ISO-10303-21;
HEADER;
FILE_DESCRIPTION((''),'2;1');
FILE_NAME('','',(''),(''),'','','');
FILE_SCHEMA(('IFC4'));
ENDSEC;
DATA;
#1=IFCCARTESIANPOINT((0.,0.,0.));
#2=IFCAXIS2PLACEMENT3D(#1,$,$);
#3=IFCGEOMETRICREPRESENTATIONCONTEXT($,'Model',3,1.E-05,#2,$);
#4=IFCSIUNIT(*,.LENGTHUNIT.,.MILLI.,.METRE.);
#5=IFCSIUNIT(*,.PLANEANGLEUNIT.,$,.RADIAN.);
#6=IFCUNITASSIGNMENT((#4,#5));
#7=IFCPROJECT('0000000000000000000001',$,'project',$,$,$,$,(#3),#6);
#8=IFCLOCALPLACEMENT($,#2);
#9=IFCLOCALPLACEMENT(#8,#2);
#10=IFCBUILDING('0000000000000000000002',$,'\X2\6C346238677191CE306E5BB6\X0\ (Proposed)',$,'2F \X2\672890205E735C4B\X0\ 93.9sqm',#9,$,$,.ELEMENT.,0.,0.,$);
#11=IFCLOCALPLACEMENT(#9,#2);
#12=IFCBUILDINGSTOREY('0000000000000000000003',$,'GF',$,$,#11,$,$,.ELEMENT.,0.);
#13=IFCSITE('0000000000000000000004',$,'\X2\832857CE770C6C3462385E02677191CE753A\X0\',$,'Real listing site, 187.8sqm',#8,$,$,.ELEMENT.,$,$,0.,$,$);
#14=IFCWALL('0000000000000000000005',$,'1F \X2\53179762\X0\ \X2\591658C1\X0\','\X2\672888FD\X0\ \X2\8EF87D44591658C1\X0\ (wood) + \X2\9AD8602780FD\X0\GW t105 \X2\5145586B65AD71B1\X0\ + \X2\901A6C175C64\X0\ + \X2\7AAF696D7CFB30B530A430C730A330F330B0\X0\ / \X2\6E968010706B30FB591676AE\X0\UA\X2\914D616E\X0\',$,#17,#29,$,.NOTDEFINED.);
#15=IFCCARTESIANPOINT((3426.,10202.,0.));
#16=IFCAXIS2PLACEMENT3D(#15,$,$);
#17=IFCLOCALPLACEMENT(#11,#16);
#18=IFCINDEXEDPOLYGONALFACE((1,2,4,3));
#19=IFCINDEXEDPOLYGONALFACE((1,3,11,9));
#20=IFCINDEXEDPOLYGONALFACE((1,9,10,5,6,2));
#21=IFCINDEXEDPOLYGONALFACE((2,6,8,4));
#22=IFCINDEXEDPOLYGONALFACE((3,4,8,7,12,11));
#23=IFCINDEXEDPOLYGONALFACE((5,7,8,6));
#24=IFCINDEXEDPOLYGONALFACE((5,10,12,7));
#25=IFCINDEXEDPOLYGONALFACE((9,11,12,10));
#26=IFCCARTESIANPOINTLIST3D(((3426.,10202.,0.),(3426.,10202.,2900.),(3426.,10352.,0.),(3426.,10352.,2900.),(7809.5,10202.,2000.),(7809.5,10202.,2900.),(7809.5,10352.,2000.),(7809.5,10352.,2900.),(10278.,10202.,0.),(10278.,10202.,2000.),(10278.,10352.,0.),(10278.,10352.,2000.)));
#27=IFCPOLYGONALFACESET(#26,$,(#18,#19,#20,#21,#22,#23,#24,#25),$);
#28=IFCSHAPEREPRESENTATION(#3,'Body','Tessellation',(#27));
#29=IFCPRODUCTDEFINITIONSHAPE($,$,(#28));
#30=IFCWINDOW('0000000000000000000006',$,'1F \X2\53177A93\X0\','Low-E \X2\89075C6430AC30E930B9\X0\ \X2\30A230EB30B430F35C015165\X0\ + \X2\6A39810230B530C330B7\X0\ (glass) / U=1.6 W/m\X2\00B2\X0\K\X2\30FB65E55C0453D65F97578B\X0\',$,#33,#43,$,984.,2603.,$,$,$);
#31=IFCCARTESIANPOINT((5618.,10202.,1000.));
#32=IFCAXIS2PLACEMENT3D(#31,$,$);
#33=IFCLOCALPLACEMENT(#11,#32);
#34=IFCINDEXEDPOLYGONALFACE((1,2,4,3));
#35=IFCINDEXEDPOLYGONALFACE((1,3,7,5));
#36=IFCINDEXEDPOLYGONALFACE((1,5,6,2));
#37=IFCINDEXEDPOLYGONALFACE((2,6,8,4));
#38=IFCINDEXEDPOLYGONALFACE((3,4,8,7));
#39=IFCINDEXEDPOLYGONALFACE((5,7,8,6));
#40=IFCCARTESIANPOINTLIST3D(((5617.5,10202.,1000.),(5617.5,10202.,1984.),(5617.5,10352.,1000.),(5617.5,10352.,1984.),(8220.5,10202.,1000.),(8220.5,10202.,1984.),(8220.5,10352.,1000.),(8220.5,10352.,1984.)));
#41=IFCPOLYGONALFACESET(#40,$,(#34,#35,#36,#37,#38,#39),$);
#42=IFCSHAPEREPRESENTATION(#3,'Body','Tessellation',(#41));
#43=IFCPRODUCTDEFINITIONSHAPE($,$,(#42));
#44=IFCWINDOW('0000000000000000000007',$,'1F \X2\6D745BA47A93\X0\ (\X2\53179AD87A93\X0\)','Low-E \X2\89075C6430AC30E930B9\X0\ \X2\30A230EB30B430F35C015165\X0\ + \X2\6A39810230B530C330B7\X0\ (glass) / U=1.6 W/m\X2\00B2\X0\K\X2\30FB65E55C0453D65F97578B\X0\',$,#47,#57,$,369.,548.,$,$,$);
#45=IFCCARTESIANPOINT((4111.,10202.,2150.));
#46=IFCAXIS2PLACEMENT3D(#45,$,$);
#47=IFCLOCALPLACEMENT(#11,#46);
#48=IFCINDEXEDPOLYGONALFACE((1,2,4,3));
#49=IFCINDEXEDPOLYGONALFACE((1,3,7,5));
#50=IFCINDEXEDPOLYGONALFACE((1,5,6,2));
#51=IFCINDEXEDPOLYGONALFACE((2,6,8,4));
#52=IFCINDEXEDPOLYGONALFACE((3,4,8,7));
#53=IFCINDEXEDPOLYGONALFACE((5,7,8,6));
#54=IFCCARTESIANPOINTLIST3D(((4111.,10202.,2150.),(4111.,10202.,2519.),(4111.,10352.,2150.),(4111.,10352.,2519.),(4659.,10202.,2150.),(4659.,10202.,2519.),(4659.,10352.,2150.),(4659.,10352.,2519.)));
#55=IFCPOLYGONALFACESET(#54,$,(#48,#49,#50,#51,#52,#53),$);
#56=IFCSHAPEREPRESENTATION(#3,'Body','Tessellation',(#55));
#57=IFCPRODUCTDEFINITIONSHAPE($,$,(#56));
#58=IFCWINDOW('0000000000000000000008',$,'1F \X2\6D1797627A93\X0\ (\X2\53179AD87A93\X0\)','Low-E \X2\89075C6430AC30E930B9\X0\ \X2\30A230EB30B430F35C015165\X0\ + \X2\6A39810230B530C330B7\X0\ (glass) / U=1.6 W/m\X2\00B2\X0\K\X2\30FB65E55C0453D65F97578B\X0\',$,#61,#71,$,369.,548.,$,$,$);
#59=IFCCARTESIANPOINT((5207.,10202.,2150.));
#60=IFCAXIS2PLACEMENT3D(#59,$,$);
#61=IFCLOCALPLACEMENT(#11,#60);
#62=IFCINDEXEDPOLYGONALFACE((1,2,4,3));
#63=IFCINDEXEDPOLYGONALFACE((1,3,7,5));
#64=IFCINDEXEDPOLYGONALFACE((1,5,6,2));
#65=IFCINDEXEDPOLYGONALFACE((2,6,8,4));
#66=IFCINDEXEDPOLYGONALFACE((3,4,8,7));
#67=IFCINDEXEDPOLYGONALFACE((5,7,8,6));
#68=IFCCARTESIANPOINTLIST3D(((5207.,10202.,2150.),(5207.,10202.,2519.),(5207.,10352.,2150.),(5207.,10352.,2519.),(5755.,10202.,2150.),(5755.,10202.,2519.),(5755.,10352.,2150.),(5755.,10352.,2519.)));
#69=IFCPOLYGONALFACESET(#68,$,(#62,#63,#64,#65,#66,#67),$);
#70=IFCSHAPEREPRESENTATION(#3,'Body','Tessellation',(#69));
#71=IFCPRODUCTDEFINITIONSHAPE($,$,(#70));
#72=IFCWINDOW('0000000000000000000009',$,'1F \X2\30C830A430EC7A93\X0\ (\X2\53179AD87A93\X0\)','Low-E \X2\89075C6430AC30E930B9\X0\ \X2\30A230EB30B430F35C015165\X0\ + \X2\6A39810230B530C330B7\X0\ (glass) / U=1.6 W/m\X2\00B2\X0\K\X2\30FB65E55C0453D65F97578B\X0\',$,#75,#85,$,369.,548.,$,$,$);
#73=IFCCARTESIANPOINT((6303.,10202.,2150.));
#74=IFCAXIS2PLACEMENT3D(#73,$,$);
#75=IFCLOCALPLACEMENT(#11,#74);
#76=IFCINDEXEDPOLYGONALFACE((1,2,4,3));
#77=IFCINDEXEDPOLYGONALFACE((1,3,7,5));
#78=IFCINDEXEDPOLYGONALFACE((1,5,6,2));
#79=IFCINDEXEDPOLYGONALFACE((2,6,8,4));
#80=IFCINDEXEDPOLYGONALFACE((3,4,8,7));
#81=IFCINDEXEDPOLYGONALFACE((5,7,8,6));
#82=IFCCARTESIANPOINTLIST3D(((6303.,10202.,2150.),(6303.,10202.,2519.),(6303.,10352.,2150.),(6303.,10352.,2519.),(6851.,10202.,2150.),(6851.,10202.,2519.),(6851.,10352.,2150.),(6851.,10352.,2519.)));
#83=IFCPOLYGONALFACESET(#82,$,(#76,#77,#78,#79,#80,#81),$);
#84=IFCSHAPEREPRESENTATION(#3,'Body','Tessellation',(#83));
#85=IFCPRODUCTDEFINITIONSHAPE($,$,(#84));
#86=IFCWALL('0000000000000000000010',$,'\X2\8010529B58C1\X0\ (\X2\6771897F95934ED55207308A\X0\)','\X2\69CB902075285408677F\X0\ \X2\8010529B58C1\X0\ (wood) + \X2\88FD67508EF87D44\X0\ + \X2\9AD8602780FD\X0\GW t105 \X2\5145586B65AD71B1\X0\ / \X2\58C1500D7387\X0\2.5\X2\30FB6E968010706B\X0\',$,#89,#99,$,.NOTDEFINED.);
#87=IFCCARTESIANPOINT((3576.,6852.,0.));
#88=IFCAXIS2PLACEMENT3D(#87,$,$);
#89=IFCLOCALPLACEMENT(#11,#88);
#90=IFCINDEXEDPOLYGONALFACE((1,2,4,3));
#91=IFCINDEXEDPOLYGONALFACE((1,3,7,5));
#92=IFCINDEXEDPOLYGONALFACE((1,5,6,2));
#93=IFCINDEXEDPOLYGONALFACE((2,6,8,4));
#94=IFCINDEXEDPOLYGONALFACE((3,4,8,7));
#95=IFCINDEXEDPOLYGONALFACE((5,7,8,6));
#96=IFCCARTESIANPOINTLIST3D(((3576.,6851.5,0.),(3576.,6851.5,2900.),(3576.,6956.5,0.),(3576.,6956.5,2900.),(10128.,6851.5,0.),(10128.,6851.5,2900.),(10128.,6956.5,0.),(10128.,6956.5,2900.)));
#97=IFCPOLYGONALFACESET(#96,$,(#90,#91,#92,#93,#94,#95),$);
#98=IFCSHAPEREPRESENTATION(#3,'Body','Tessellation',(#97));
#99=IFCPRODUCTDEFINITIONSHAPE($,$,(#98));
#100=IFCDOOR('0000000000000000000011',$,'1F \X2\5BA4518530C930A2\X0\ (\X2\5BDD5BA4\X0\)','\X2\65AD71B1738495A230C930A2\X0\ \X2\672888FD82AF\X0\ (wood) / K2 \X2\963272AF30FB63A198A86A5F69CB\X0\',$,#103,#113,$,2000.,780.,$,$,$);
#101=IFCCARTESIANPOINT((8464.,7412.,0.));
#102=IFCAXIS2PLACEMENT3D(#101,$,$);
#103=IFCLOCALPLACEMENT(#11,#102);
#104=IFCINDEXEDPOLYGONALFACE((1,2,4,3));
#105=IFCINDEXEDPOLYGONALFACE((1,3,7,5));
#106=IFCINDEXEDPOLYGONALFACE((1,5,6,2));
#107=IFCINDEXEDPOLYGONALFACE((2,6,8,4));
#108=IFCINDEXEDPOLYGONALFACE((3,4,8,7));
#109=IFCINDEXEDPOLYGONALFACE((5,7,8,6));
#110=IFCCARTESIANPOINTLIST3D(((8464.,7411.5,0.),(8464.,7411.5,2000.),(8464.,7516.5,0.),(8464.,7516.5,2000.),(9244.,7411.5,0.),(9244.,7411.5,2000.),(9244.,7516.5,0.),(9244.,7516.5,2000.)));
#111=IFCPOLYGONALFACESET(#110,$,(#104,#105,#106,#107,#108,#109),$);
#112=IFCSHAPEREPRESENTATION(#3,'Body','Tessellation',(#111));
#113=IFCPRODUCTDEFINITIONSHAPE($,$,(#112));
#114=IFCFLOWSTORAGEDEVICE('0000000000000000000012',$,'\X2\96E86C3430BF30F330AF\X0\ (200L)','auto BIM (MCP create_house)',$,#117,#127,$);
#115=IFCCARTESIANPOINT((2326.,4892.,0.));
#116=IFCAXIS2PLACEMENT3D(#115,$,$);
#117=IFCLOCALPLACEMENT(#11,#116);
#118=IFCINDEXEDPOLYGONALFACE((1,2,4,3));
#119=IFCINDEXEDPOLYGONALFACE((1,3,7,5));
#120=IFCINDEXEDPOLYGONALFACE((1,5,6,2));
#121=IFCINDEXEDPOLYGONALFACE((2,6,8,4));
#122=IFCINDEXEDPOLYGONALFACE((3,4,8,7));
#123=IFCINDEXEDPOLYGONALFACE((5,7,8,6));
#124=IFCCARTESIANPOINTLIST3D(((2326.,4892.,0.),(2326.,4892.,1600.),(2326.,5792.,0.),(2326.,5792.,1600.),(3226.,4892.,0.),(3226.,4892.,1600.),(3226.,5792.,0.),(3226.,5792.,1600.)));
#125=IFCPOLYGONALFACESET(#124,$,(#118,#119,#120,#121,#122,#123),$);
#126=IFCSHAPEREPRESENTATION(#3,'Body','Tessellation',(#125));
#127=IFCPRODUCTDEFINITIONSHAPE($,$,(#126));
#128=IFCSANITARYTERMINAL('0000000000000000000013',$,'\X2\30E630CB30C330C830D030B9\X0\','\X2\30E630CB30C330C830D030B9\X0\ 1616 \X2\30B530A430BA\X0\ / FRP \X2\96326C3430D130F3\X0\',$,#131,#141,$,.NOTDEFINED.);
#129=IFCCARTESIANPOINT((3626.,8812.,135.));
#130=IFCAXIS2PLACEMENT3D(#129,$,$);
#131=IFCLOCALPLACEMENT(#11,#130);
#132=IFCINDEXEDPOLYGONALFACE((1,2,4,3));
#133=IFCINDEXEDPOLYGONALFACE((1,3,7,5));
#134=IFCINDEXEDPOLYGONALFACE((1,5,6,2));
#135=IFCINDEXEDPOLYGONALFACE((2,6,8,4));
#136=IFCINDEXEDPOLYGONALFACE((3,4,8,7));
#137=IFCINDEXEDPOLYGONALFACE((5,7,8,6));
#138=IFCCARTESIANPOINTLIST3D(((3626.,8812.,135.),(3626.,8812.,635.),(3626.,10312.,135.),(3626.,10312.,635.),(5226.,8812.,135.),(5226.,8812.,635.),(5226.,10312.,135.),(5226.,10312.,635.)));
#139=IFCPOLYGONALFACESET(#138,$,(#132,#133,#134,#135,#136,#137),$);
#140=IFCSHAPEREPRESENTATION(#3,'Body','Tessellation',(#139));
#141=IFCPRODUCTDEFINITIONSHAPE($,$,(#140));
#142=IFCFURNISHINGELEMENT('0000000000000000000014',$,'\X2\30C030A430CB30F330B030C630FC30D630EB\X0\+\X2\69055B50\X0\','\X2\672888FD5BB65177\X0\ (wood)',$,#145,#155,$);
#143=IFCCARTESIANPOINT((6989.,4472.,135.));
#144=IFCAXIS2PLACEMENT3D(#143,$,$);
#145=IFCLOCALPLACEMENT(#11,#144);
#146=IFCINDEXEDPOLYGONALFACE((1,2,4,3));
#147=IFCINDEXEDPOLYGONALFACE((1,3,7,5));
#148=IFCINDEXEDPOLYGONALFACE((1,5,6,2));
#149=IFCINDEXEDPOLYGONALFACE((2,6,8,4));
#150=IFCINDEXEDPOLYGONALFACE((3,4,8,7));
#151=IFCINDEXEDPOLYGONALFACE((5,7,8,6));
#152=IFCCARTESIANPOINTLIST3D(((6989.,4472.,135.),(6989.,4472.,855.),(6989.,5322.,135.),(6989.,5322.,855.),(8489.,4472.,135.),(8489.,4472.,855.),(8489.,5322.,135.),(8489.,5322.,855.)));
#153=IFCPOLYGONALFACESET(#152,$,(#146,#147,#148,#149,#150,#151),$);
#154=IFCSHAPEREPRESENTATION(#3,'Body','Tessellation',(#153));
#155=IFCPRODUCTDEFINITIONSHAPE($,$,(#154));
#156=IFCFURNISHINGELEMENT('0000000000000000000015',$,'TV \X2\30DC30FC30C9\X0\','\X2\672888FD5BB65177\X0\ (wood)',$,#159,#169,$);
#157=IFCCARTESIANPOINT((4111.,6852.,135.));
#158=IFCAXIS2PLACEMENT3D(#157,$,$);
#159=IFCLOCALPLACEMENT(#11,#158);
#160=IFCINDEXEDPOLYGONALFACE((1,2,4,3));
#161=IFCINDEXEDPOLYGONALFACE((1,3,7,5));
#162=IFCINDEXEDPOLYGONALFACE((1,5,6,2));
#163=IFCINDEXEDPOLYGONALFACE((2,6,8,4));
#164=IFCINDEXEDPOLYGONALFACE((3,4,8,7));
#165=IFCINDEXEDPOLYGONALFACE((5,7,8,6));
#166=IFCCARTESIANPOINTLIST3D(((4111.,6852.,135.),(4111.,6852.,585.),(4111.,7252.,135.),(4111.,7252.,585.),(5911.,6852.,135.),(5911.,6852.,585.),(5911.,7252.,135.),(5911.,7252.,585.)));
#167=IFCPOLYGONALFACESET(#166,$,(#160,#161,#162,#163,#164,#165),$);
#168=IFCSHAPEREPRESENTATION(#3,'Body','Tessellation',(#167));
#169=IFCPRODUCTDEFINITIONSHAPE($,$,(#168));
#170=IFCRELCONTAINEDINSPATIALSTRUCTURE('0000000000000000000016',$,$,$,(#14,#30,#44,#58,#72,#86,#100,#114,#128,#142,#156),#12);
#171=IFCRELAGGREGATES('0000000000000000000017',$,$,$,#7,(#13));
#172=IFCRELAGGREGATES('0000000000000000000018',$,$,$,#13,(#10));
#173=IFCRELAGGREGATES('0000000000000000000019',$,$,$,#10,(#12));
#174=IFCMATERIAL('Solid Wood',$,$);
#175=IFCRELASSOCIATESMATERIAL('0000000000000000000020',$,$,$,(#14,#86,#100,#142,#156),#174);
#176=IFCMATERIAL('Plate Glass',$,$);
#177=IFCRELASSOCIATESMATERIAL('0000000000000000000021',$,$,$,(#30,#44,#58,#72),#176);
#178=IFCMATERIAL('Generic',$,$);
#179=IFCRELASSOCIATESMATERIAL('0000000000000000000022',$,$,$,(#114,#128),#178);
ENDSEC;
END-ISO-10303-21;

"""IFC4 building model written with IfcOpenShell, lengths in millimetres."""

from ifc_helpers import new_model, si_unit, frame, frame_2d, origin, place, context, project, spatial, rectangle, extrude, material, element, fill, save


model = new_model("IFC4")

# Units and contexts
model_context = context("Model", 3, precision=1e-05, world=origin())
ifc_project = project(units=[si_unit("LENGTHUNIT", "METRE", prefix="MILLI"), si_unit("PLANEANGLEUNIT", "RADIAN")], contexts=[model_context])

# Site, building, storey
site_placement = place(None, origin())
site = spatial("IfcSite", under=ifc_project, at=site_placement, Name="茨城県水戸市東野町", ObjectType="Real listing site, 187.8sqm", CompositionType="ELEMENT", RefElevation=0.0)
building_placement = place(site_placement, origin())
building = spatial("IfcBuilding", under=site, at=building_placement, Name="水戸東野の家 (Proposed)", ObjectType="2F 木造平屋 93.9sqm", CompositionType="ELEMENT", ElevationOfRefHeight=0.0, ElevationOfTerrain=0.0)
storey_placement = place(building_placement, origin())
storey = spatial("IfcBuildingStorey", under=building, at=storey_placement, Name="GF", CompositionType="ELEMENT", Elevation=0.0)

# Wall, openings, windows
ifc_material_1 = material(Name="Solid Wood")
wall_1_placement = place(storey_placement, frame((3426.0, 10202.0, 0.0)))
wall_1 = element("IfcWall", 1, at=wall_1_placement, inside=storey, material=ifc_material_1, Name="1F 北面 外壁", Description="木製 軸組外壁 (wood) + 高性能GW t105 充填断熱 + 通気層 + 窯業系サイディング / 準耐火・外皮UA配慮", PredefinedType="NOTDEFINED", context=model_context, shape_type="SweptSolid", body=[
    extrude(rectangle(XDim=6852.0, YDim=150.0, at=frame_2d((3426.0, 75.0))), frame((3426.0, 10202.0, 0.0)), (0.0, 0.0, 1.0), 2900.0),
])
opening_1_placement = place(storey_placement, frame((5618.0, 10202.0, 1000.0)))
opening_1 = element("IfcOpeningElement", 2, at=opening_1_placement, cuts=wall_1, PredefinedType="NOTDEFINED", context=model_context, shape_type="SweptSolid", body=[
    extrude(rectangle(XDim=2603.0, YDim=150.0, at=frame_2d((1301.0, 75.0))), frame((5618.0, 10202.0, 1000.0)), (0.0, 0.0, 1.0), 984.0),
])
opening_2_placement = place(storey_placement, frame((4111.0, 10202.0, 2150.0)))
opening_2 = element("IfcOpeningElement", 3, at=opening_2_placement, cuts=wall_1, PredefinedType="NOTDEFINED", context=model_context, shape_type="SweptSolid", body=[
    extrude(rectangle(XDim=548.0, YDim=150.0, at=frame_2d((274.0, 75.0))), frame((4111.0, 10202.0, 2150.0)), (0.0, 0.0, 1.0), 369.0),
])
opening_3_placement = place(storey_placement, frame((5207.0, 10202.0, 2150.0)))
opening_3 = element("IfcOpeningElement", 4, at=opening_3_placement, cuts=wall_1, PredefinedType="NOTDEFINED", context=model_context, shape_type="SweptSolid", body=[
    extrude(rectangle(XDim=548.0, YDim=150.0, at=frame_2d((274.0, 75.0))), frame((5207.0, 10202.0, 2150.0)), (0.0, 0.0, 1.0), 369.0),
])
opening_4_placement = place(storey_placement, frame((6303.0, 10202.0, 2150.0)))
opening_4 = element("IfcOpeningElement", 5, at=opening_4_placement, cuts=wall_1, PredefinedType="NOTDEFINED", context=model_context, shape_type="SweptSolid", body=[
    extrude(rectangle(XDim=548.0, YDim=150.0, at=frame_2d((274.0, 75.0))), frame((6303.0, 10202.0, 2150.0)), (0.0, 0.0, 1.0), 369.0),
])
ifc_material_2 = material(Name="Plate Glass")
window_1_placement = place(storey_placement, frame((5618.0, 10202.0, 1000.0)))
window_1 = element("IfcWindow", 6, at=window_1_placement, inside=storey, material=ifc_material_2, Name="1F 北窓", Description="Low-E 複層ガラス アルゴン封入 + 樹脂サッシ (glass) / U=1.6 W/m²K・日射取得型", OverallHeight=984.0, OverallWidth=2603.0, context=model_context, shape_type="SweptSolid", body=[
    extrude(rectangle(XDim=2603.0, YDim=150.0, at=frame_2d((1301.0, 75.0))), frame((5618.0, 10202.0, 1000.0)), (0.0, 0.0, 1.0), 984.0),
])
fill(opening_1, window_1)
window_2_placement = place(storey_placement, frame((4111.0, 10202.0, 2150.0)))
window_2 = element("IfcWindow", 7, at=window_2_placement, inside=storey, material=ifc_material_2, Name="1F 浴室窓 (北高窓)", Description="Low-E 複層ガラス アルゴン封入 + 樹脂サッシ (glass) / U=1.6 W/m²K・日射取得型", OverallHeight=369.0, OverallWidth=548.0, context=model_context, shape_type="SweptSolid", body=[
    extrude(rectangle(XDim=548.0, YDim=150.0, at=frame_2d((274.0, 75.0))), frame((4111.0, 10202.0, 2150.0)), (0.0, 0.0, 1.0), 369.0),
])
fill(opening_2, window_2)
window_3_placement = place(storey_placement, frame((5207.0, 10202.0, 2150.0)))
window_3 = element("IfcWindow", 8, at=window_3_placement, inside=storey, material=ifc_material_2, Name="1F 洗面窓 (北高窓)", Description="Low-E 複層ガラス アルゴン封入 + 樹脂サッシ (glass) / U=1.6 W/m²K・日射取得型", OverallHeight=369.0, OverallWidth=548.0, context=model_context, shape_type="SweptSolid", body=[
    extrude(rectangle(XDim=548.0, YDim=150.0, at=frame_2d((274.0, 75.0))), frame((5207.0, 10202.0, 2150.0)), (0.0, 0.0, 1.0), 369.0),
])
fill(opening_3, window_3)
window_4_placement = place(storey_placement, frame((6303.0, 10202.0, 2150.0)))
window_4 = element("IfcWindow", 9, at=window_4_placement, inside=storey, material=ifc_material_2, Name="1F トイレ窓 (北高窓)", Description="Low-E 複層ガラス アルゴン封入 + 樹脂サッシ (glass) / U=1.6 W/m²K・日射取得型", OverallHeight=369.0, OverallWidth=548.0, context=model_context, shape_type="SweptSolid", body=[
    extrude(rectangle(XDim=548.0, YDim=150.0, at=frame_2d((274.0, 75.0))), frame((6303.0, 10202.0, 2150.0)), (0.0, 0.0, 1.0), 369.0),
])
fill(opening_4, window_4)

# Wall
wall_2_placement = place(storey_placement, frame((3576.0, 6852.0, 0.0)))
element("IfcWall", 10, at=wall_2_placement, inside=storey, material=ifc_material_1, Name="耐力壁 (東西間仕切り)", Description="構造用合板 耐力壁 (wood) + 製材軸組 + 高性能GW t105 充填断熱 / 壁倍率2.5・準耐火", PredefinedType="NOTDEFINED", context=model_context, shape_type="SweptSolid", body=[
    extrude(rectangle(XDim=6552.0, YDim=105.0, at=frame_2d((3276.0, 52.0))), frame((3576.0, 6852.0, 0.0)), (0.0, 0.0, 1.0), 2900.0),
])

# Door
door_1_placement = place(storey_placement, frame((8464.0, 7412.0, 0.0)))
element("IfcDoor", 11, at=door_1_placement, inside=storey, material=ifc_material_1, Name="1F 室内ドア (寝室)", Description="断熱玄関ドア 木製芯 (wood) / K2 防犯・採風機構", OverallHeight=2000.0, OverallWidth=780.0, context=model_context, shape_type="SweptSolid", body=[
    extrude(rectangle(XDim=780.0, YDim=105.0, at=frame_2d((390.0, 52.0))), frame((8464.0, 7412.0, 0.0)), (0.0, 0.0, 1.0), 2000.0),
])

# Flow storage device
ifc_material_3 = material(Name="Generic")
flow_storage_device_placement = place(storey_placement, frame((2326.0, 4892.0, 0.0)))
element("IfcFlowStorageDevice", 12, at=flow_storage_device_placement, inside=storey, material=ifc_material_3, Name="雨水タンク (200L)", Description="auto BIM (MCP create_house)", context=model_context, shape_type="SweptSolid", body=[
    extrude(rectangle(XDim=900.0, YDim=900.0, at=frame_2d((450.0, 450.0))), frame((2326.0, 4892.0, 0.0)), (0.0, 0.0, 1.0), 1600.0),
])

# Sanitary terminal
sanitary_terminal_placement = place(storey_placement, frame((3626.0, 8812.0, 135.0)))
element("IfcSanitaryTerminal", 13, at=sanitary_terminal_placement, inside=storey, material=ifc_material_3, Name="ユニットバス", Description="ユニットバス 1616 サイズ / FRP 防水パン", PredefinedType="NOTDEFINED", context=model_context, shape_type="SweptSolid", body=[
    extrude(rectangle(XDim=1600.0, YDim=1500.0, at=frame_2d((800.0, 750.0))), frame((3626.0, 8812.0, 135.0)), (0.0, 0.0, 1.0), 500.0),
])

# Furnishing elements
furnishing_1_placement = place(storey_placement, frame((6989.0, 4472.0, 135.0)))
element("IfcFurnishingElement", 14, at=furnishing_1_placement, inside=storey, material=ifc_material_1, Name="ダイニングテーブル+椅子", Description="木製家具 (wood)", context=model_context, shape_type="SweptSolid", body=[
    extrude(rectangle(XDim=1500.0, YDim=850.0, at=frame_2d((750.0, 425.0))), frame((6989.0, 4472.0, 135.0)), (0.0, 0.0, 1.0), 720.0),
])
furnishing_2_placement = place(storey_placement, frame((4111.0, 6852.0, 135.0)))
element("IfcFurnishingElement", 15, at=furnishing_2_placement, inside=storey, material=ifc_material_1, Name="TV ボード", Description="木製家具 (wood)", context=model_context, shape_type="SweptSolid", body=[
    extrude(rectangle(XDim=1800.0, YDim=400.0, at=frame_2d((900.0, 200.0))), frame((4111.0, 6852.0, 135.0)), (0.0, 0.0, 1.0), 450.0),
])

save(model, "model.ifc")
